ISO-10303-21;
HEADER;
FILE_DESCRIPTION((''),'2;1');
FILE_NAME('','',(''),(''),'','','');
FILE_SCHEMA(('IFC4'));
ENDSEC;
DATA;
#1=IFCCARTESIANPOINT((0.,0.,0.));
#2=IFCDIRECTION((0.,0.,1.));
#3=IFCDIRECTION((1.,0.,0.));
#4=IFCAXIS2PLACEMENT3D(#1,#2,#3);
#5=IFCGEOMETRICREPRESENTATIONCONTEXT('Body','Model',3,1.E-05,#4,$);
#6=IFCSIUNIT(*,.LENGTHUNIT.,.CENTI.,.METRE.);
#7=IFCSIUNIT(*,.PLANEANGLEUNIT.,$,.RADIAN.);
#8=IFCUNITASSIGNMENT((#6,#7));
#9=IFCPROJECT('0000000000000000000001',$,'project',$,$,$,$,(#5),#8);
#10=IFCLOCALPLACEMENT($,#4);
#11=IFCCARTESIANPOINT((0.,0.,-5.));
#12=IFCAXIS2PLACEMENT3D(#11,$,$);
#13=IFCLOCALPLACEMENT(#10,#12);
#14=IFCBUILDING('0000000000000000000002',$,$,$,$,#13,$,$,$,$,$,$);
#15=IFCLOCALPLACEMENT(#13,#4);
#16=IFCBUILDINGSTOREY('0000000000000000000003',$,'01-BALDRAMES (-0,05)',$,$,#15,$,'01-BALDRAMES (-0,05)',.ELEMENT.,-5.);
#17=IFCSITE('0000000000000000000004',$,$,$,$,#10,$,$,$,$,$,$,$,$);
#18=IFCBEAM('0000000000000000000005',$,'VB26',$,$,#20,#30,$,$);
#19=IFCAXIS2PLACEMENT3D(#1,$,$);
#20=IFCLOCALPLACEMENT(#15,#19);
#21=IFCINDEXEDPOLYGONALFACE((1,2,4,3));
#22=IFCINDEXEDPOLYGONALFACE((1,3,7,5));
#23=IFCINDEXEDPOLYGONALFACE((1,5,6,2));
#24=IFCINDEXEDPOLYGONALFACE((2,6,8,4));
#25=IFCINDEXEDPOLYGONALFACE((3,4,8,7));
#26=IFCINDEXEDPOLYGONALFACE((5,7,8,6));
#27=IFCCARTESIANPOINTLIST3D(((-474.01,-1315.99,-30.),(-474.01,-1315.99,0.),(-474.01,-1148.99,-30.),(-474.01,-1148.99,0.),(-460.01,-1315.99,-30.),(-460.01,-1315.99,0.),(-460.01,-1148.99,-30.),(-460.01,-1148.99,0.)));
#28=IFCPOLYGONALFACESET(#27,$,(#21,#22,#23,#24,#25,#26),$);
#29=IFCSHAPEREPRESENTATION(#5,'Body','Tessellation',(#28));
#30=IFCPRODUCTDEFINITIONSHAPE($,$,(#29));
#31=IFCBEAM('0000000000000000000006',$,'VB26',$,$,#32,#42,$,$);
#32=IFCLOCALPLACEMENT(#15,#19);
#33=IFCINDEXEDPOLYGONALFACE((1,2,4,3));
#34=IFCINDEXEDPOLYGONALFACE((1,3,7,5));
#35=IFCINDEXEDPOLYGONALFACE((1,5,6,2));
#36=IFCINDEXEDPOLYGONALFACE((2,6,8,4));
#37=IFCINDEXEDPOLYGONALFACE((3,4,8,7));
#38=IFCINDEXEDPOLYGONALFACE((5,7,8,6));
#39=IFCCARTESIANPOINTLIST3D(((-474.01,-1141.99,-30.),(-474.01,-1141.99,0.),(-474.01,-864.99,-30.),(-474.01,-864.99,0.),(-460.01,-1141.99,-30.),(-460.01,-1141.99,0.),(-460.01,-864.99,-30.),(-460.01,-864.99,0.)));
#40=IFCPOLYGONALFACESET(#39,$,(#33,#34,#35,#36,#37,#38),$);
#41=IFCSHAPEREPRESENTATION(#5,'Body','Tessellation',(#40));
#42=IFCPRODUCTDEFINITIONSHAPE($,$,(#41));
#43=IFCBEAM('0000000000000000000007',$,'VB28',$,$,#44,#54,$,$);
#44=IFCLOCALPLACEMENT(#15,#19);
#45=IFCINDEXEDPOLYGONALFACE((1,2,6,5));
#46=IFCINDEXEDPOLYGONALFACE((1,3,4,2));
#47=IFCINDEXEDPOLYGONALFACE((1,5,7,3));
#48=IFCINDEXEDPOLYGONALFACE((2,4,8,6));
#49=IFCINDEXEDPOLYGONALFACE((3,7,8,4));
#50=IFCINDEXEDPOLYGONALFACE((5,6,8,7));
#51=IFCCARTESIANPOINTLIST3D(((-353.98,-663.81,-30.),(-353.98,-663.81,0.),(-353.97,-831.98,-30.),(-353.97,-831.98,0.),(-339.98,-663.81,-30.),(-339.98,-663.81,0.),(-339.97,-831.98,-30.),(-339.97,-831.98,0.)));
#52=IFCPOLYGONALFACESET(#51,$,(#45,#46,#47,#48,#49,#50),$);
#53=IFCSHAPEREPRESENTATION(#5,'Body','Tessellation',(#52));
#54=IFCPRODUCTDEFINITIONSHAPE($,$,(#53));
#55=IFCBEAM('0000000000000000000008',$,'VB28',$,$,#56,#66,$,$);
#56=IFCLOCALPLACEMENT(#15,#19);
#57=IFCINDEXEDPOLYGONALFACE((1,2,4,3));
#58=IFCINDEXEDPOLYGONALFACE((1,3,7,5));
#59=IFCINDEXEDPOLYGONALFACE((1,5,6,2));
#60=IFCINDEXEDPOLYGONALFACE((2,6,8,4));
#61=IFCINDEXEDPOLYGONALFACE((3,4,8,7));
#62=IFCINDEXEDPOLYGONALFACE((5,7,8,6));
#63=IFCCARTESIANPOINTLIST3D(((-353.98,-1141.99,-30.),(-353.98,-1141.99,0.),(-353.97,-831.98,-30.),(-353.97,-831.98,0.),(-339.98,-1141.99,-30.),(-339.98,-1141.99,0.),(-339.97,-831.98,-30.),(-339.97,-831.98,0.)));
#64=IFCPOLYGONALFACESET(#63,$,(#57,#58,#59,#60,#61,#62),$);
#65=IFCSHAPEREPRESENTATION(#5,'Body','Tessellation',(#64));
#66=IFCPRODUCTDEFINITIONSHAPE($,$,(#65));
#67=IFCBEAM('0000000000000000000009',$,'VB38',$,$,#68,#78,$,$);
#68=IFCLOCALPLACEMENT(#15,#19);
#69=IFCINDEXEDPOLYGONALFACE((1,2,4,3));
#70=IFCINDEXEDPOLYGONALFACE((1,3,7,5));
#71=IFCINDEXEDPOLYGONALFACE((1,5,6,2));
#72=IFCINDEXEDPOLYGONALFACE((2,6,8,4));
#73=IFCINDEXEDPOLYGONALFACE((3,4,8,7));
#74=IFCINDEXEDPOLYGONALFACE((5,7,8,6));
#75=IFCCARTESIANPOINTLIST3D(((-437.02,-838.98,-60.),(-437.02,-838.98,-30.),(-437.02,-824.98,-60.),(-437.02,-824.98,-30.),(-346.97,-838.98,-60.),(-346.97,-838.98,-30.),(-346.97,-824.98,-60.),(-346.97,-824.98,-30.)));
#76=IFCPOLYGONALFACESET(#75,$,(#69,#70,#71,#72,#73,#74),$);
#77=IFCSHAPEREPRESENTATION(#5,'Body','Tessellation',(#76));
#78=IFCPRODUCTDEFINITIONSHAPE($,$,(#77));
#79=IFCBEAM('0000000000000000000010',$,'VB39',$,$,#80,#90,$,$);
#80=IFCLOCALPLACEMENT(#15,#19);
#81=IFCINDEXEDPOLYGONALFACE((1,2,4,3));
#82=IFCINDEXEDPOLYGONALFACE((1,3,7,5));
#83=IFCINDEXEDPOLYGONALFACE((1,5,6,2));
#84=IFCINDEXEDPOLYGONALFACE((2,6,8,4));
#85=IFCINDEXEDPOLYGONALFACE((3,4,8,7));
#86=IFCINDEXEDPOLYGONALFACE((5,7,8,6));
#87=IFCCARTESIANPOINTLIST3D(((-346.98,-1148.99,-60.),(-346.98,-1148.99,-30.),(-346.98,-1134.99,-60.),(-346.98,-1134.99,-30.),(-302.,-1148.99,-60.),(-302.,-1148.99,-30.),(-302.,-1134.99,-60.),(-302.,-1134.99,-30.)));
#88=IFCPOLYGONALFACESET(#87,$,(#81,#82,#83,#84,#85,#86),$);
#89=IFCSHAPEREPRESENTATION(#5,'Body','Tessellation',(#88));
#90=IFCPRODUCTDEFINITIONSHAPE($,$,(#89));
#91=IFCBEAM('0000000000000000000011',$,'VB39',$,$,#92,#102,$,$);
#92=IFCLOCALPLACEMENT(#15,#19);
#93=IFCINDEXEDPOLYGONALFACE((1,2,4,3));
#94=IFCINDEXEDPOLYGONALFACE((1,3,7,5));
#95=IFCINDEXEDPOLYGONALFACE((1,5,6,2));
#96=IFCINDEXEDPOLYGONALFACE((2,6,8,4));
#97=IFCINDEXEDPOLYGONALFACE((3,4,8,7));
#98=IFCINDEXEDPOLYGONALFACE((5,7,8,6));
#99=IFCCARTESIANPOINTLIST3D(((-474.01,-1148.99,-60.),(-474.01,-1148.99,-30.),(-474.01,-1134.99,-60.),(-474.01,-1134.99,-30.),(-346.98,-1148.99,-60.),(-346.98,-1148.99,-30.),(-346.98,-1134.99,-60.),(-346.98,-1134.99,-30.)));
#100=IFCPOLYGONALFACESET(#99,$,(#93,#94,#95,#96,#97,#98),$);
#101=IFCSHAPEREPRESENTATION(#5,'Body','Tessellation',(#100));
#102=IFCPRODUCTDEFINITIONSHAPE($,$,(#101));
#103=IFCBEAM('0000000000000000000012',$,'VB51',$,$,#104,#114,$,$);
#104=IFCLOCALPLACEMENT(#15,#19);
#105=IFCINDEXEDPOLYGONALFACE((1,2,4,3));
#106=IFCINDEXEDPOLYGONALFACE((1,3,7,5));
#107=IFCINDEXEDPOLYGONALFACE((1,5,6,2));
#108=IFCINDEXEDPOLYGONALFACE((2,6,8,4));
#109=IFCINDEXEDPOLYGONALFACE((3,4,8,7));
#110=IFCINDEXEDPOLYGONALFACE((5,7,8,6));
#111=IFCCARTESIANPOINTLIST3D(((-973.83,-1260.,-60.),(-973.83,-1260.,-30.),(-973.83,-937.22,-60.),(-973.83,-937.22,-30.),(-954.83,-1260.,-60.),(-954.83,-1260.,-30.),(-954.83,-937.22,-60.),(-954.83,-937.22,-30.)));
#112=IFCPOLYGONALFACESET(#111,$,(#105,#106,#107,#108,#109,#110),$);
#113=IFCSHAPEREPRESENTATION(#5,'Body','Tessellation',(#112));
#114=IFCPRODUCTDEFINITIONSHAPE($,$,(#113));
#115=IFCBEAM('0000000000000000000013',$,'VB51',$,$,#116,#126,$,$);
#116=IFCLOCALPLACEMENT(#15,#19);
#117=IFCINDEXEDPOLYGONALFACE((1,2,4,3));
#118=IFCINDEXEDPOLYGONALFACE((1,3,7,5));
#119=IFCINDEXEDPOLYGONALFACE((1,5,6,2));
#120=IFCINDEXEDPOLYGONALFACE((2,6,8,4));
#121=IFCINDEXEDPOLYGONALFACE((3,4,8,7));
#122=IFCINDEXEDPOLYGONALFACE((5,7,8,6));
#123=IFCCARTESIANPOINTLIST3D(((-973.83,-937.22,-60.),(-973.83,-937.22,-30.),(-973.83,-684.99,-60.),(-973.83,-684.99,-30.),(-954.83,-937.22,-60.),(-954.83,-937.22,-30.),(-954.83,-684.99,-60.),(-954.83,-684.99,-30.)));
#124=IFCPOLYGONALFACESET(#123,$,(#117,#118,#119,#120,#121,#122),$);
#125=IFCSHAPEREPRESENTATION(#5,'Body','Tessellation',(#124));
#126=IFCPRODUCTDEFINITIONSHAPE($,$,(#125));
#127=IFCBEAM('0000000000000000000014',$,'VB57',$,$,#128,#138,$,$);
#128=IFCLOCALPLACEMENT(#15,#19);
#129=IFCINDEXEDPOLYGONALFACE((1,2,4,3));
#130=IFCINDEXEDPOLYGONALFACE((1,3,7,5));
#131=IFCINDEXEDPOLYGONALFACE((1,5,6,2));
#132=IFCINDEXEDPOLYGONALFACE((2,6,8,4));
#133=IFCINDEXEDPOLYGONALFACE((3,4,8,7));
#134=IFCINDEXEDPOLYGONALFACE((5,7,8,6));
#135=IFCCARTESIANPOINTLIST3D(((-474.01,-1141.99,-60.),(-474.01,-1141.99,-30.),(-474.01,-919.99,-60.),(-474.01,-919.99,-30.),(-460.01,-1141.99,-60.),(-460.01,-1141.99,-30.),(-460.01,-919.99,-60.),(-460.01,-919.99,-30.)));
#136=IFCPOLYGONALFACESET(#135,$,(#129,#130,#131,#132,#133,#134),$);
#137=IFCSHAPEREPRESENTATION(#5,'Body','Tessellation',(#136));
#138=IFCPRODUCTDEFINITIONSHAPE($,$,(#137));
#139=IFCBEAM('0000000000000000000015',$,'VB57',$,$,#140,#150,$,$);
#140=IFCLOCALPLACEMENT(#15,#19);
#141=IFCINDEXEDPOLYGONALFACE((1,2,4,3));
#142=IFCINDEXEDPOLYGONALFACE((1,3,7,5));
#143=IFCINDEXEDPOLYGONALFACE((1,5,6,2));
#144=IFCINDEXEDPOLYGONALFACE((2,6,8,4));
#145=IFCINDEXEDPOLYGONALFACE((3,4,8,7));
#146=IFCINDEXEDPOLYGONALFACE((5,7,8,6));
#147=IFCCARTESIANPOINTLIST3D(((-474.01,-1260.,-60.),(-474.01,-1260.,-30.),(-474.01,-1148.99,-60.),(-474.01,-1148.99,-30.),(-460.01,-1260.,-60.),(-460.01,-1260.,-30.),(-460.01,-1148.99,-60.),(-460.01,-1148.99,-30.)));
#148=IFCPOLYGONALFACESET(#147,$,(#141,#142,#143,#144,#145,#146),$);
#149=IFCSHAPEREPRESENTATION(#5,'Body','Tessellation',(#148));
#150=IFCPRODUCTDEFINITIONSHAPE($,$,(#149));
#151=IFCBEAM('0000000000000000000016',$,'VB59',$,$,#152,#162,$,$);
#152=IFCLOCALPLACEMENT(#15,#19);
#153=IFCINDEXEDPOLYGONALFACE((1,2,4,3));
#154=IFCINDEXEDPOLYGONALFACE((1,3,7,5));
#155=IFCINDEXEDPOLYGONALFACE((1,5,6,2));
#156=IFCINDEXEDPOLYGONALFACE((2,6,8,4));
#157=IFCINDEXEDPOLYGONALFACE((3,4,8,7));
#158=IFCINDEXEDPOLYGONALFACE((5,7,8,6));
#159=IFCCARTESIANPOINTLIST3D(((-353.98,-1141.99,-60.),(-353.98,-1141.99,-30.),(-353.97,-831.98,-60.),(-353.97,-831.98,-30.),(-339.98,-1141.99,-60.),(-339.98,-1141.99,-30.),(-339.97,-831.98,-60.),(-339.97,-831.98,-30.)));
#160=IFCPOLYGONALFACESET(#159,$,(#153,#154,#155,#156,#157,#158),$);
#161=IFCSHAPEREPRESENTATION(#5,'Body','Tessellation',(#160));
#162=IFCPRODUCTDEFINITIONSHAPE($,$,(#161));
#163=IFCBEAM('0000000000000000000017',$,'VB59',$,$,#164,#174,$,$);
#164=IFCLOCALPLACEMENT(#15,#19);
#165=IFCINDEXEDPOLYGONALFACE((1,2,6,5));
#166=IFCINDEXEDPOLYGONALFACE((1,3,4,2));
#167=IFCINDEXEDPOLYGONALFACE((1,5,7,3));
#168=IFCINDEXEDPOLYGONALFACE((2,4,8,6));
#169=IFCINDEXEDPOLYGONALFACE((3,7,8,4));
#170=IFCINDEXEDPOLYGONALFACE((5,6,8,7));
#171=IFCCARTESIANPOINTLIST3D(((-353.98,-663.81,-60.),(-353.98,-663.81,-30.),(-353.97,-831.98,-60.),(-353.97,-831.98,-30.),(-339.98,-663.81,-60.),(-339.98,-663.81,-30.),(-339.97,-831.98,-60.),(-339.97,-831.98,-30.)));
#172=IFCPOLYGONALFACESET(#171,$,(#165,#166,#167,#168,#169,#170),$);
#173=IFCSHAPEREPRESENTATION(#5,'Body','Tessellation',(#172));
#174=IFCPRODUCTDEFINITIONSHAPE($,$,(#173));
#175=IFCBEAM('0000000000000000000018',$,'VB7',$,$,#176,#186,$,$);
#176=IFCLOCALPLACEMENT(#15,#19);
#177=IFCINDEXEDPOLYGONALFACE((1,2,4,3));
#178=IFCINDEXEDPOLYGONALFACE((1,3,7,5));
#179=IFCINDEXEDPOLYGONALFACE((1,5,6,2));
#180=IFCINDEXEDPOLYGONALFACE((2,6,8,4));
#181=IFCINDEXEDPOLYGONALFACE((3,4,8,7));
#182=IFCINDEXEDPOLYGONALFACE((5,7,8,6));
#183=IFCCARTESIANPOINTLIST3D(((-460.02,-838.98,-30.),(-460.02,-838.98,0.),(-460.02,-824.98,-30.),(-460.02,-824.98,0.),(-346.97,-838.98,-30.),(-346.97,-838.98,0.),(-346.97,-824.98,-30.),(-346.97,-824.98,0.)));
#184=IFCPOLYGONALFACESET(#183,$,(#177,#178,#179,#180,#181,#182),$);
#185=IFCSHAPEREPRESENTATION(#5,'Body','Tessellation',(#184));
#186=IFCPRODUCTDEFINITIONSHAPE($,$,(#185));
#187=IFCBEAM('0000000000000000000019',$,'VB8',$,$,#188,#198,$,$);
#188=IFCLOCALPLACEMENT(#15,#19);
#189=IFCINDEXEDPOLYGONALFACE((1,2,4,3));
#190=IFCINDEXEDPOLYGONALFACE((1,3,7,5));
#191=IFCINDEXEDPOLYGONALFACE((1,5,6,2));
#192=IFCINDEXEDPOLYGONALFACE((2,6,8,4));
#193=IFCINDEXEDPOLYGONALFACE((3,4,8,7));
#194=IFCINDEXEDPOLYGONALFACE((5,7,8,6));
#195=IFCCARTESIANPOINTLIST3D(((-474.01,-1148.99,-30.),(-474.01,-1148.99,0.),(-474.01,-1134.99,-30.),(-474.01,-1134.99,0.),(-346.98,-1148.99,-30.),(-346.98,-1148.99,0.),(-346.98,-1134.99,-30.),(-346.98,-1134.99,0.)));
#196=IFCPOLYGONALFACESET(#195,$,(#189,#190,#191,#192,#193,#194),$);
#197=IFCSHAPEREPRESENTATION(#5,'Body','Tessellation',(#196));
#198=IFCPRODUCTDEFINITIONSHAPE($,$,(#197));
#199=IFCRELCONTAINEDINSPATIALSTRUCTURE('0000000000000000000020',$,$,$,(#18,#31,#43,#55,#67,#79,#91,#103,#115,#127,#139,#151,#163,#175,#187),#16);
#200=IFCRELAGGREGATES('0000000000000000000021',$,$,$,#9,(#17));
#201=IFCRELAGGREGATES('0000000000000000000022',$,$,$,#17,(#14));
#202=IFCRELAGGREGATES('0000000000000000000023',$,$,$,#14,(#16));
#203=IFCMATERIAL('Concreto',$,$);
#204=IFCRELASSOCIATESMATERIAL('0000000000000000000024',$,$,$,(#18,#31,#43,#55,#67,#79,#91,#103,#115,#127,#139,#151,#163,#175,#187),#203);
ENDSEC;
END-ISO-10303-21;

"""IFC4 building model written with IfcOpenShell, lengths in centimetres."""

from ifc_helpers import new_model, si_unit, frame, origin_with_axes, origin_2d_with_axis, place, context, project, spatial, rectangle, extrude, material, element, save


model = new_model("IFC4")

# Units and contexts
model_context = context("Model", 3, precision=1e-05, world=origin_with_axes(), identifier="Body")
ifc_project = project(units=[si_unit("LENGTHUNIT", "METRE", prefix="CENTI"), si_unit("PLANEANGLEUNIT", "RADIAN")], contexts=[model_context])

# Site, building, storey
site_placement = place(None, origin_with_axes())
site = spatial("IfcSite", under=ifc_project, at=site_placement)
building_placement = place(site_placement, frame((0.0, 0.0, -5.0)))
building = spatial("IfcBuilding", under=site, at=building_placement)
storey_placement = place(building_placement, origin_with_axes())
storey = spatial("IfcBuildingStorey", under=building, at=storey_placement, Name="01-BALDRAMES (-0,05)", LongName="01-BALDRAMES (-0,05)", CompositionType="ELEMENT", Elevation=-5.0)

# Shared definitions
ifc_material = material(Name="Concreto")

# Beams
beam_1_placement = place(storey_placement, frame((-467.01, -1232.49, 0.0), z_axis=(0.0, 0.0, 1.0), x_axis=(1.0, 0.0, 0.0)))
element("IfcBeam", 1, at=beam_1_placement, inside=storey, material=ifc_material, Name="VB26", context=model_context, shape_type="SolidModel", body=[
    extrude(rectangle(XDim=14.0, YDim=30.0, at=origin_2d_with_axis()), frame((0.0, -83.5, -15.0), z_axis=(0.0, 1.0, 0.0), x_axis=(1.0, 0.0, 0.0)), (0.0, 0.0, 1.0), 167.0),
])
beam_2_placement = place(storey_placement, frame((-467.01, -1003.49, 0.0), z_axis=(0.0, 0.0, 1.0), x_axis=(1.0, 0.0, 0.0)))
element("IfcBeam", 2, at=beam_2_placement, inside=storey, material=ifc_material, Name="VB26", context=model_context, shape_type="SolidModel", body=[
    extrude(rectangle(XDim=14.0, YDim=30.0, at=origin_2d_with_axis()), frame((0.0, -138.5, -15.0), z_axis=(0.0, 1.0, 0.0), x_axis=(1.0, 0.0, 0.0)), (0.0, 0.0, 1.0), 277.0),
])
beam_3_placement = place(storey_placement, frame((-346.98, -747.89, 0.0), z_axis=(0.0, 0.0, 1.0), x_axis=(1.0, 0.0, 0.0)))
element("IfcBeam", 3, at=beam_3_placement, inside=storey, material=ifc_material, Name="VB28", context=model_context, shape_type="SolidModel", body=[
    extrude(rectangle(XDim=14.0, YDim=30.0, at=origin_2d_with_axis()), frame((0.01, -84.09, -15.0), z_axis=(-0.000059, 1.0, 0.0), x_axis=(1.0, 0.000059, 0.0)), (0.0, 0.0, 1.0), 168.17),
])
beam_4_placement = place(storey_placement, frame((-346.98, -986.99, 0.0), z_axis=(0.0, 0.0, 1.0), x_axis=(1.0, 0.0, 0.0)))
element("IfcBeam", 4, at=beam_4_placement, inside=storey, material=ifc_material, Name="VB28", context=model_context, shape_type="SolidModel", body=[
    extrude(rectangle(XDim=14.0, YDim=30.0, at=origin_2d_with_axis()), frame((-0.01, -155.0, -15.0), z_axis=(0.000032, 1.0, 0.0), x_axis=(1.0, -0.000032, 0.0)), (0.0, 0.0, 1.0), 310.01),
])
beam_5_placement = place(storey_placement, frame((-392.0, -831.98, -30.0), z_axis=(0.0, 0.0, 1.0), x_axis=(1.0, 0.0, 0.0)))
element("IfcBeam", 5, at=beam_5_placement, inside=storey, material=ifc_material, Name="VB38", context=model_context, shape_type="SolidModel", body=[
    extrude(rectangle(XDim=14.0, YDim=30.0, at=origin_2d_with_axis()), frame((-45.02, 0.0, -15.0), z_axis=(1.0, 0.0, 0.0), x_axis=(0.0, -1.0, 0.0)), (0.0, 0.0, 1.0), 90.05),
])
beam_6_placement = place(storey_placement, frame((-324.49, -1141.99, -30.0), z_axis=(0.0, 0.0, 1.0), x_axis=(1.0, 0.0, 0.0)))
element("IfcBeam", 6, at=beam_6_placement, inside=storey, material=ifc_material, Name="VB39", context=model_context, shape_type="SolidModel", body=[
    extrude(rectangle(XDim=14.0, YDim=30.0, at=origin_2d_with_axis()), frame((-22.49, 0.0, -15.0), z_axis=(1.0, 0.0, 0.0), x_axis=(0.0, -1.0, 0.0)), (0.0, 0.0, 1.0), 44.98),
])
beam_7_placement = place(storey_placement, frame((-410.5, -1141.99, -30.0), z_axis=(0.0, 0.0, 1.0), x_axis=(1.0, 0.0, 0.0)))
element("IfcBeam", 7, at=beam_7_placement, inside=storey, material=ifc_material, Name="VB39", context=model_context, shape_type="SolidModel", body=[
    extrude(rectangle(XDim=14.0, YDim=30.0, at=origin_2d_with_axis()), frame((-63.52, 0.0, -15.0), z_axis=(1.0, 0.0, 0.0), x_axis=(0.0, -1.0, 0.0)), (0.0, 0.0, 1.0), 127.03),
])
beam_8_placement = place(storey_placement, frame((-964.33, -1098.61, -30.0), z_axis=(0.0, 0.0, 1.0), x_axis=(1.0, 0.0, 0.0)))
element("IfcBeam", 8, at=beam_8_placement, inside=storey, material=ifc_material, Name="VB51", context=model_context, shape_type="SolidModel", body=[
    extrude(rectangle(XDim=19.0, YDim=30.0, at=origin_2d_with_axis()), frame((0.0, -161.39, -15.0), z_axis=(0.0, 1.0, 0.0), x_axis=(-1.0, 0.0, 0.0)), (0.0, 0.0, 1.0), 322.78),
])
beam_9_placement = place(storey_placement, frame((-964.33, -811.11, -30.0), z_axis=(0.0, 0.0, 1.0), x_axis=(1.0, 0.0, 0.0)))
element("IfcBeam", 9, at=beam_9_placement, inside=storey, material=ifc_material, Name="VB51", context=model_context, shape_type="SolidModel", body=[
    extrude(rectangle(XDim=19.0, YDim=30.0, at=origin_2d_with_axis()), frame((0.0, -126.11, -15.0), z_axis=(0.0, 1.0, 0.0), x_axis=(-1.0, 0.0, 0.0)), (0.0, 0.0, 1.0), 252.23),
])
beam_10_placement = place(storey_placement, frame((-467.01, -1030.99, -30.0), z_axis=(0.0, 0.0, 1.0), x_axis=(1.0, 0.0, 0.0)))
element("IfcBeam", 10, at=beam_10_placement, inside=storey, material=ifc_material, Name="VB57", context=model_context, shape_type="SolidModel", body=[
    extrude(rectangle(XDim=14.0, YDim=30.0, at=origin_2d_with_axis()), frame((0.0, -111.0, -15.0), z_axis=(0.0, 1.0, 0.0), x_axis=(1.0, 0.0, 0.0)), (0.0, 0.0, 1.0), 222.0),
])
beam_11_placement = place(storey_placement, frame((-467.01, -1204.49, -30.0), z_axis=(0.0, 0.0, 1.0), x_axis=(1.0, 0.0, 0.0)))
element("IfcBeam", 11, at=beam_11_placement, inside=storey, material=ifc_material, Name="VB57", context=model_context, shape_type="SolidModel", body=[
    extrude(rectangle(XDim=14.0, YDim=30.0, at=origin_2d_with_axis()), frame((0.0, -55.51, -15.0), z_axis=(0.0, 1.0, 0.0), x_axis=(1.0, 0.0, 0.0)), (0.0, 0.0, 1.0), 111.01),
])
beam_12_placement = place(storey_placement, frame((-346.98, -986.99, -30.0), z_axis=(0.0, 0.0, 1.0), x_axis=(1.0, 0.0, 0.0)))
element("IfcBeam", 12, at=beam_12_placement, inside=storey, material=ifc_material, Name="VB59", context=model_context, shape_type="SolidModel", body=[
    extrude(rectangle(XDim=14.0, YDim=30.0, at=origin_2d_with_axis()), frame((-0.01, -155.0, -15.0), z_axis=(0.000032, 1.0, 0.0), x_axis=(1.0, -0.000032, 0.0)), (0.0, 0.0, 1.0), 310.01),
])
beam_13_placement = place(storey_placement, frame((-346.98, -747.89, -30.0), z_axis=(0.0, 0.0, 1.0), x_axis=(1.0, 0.0, 0.0)))
element("IfcBeam", 13, at=beam_13_placement, inside=storey, material=ifc_material, Name="VB59", context=model_context, shape_type="SolidModel", body=[
    extrude(rectangle(XDim=14.0, YDim=30.0, at=origin_2d_with_axis()), frame((0.01, -84.09, -15.0), z_axis=(-0.000059, 1.0, 0.0), x_axis=(1.0, 0.000059, 0.0)), (0.0, 0.0, 1.0), 168.17),
])
beam_14_placement = place(storey_placement, frame((-403.5, -831.98, 0.0), z_axis=(0.0, 0.0, 1.0), x_axis=(1.0, 0.0, 0.0)))
element("IfcBeam", 14, at=beam_14_placement, inside=storey, material=ifc_material, Name="VB7", context=model_context, shape_type="SolidModel", body=[
    extrude(rectangle(XDim=14.0, YDim=30.0, at=origin_2d_with_axis()), frame((-56.52, 0.0, -15.0), z_axis=(1.0, 0.0, 0.0), x_axis=(0.0, -1.0, 0.0)), (0.0, 0.0, 1.0), 113.05),
])
beam_15_placement = place(storey_placement, frame((-410.5, -1141.99, 0.0), z_axis=(0.0, 0.0, 1.0), x_axis=(1.0, 0.0, 0.0)))
element("IfcBeam", 15, at=beam_15_placement, inside=storey, material=ifc_material, Name="VB8", context=model_context, shape_type="SolidModel", body=[
    extrude(rectangle(XDim=14.0, YDim=30.0, at=origin_2d_with_axis()), frame((-63.52, 0.0, -15.0), z_axis=(1.0, 0.0, 0.0), x_axis=(0.0, -1.0, 0.0)), (0.0, 0.0, 1.0), 127.03),
])

save(model, "model.ifc")
